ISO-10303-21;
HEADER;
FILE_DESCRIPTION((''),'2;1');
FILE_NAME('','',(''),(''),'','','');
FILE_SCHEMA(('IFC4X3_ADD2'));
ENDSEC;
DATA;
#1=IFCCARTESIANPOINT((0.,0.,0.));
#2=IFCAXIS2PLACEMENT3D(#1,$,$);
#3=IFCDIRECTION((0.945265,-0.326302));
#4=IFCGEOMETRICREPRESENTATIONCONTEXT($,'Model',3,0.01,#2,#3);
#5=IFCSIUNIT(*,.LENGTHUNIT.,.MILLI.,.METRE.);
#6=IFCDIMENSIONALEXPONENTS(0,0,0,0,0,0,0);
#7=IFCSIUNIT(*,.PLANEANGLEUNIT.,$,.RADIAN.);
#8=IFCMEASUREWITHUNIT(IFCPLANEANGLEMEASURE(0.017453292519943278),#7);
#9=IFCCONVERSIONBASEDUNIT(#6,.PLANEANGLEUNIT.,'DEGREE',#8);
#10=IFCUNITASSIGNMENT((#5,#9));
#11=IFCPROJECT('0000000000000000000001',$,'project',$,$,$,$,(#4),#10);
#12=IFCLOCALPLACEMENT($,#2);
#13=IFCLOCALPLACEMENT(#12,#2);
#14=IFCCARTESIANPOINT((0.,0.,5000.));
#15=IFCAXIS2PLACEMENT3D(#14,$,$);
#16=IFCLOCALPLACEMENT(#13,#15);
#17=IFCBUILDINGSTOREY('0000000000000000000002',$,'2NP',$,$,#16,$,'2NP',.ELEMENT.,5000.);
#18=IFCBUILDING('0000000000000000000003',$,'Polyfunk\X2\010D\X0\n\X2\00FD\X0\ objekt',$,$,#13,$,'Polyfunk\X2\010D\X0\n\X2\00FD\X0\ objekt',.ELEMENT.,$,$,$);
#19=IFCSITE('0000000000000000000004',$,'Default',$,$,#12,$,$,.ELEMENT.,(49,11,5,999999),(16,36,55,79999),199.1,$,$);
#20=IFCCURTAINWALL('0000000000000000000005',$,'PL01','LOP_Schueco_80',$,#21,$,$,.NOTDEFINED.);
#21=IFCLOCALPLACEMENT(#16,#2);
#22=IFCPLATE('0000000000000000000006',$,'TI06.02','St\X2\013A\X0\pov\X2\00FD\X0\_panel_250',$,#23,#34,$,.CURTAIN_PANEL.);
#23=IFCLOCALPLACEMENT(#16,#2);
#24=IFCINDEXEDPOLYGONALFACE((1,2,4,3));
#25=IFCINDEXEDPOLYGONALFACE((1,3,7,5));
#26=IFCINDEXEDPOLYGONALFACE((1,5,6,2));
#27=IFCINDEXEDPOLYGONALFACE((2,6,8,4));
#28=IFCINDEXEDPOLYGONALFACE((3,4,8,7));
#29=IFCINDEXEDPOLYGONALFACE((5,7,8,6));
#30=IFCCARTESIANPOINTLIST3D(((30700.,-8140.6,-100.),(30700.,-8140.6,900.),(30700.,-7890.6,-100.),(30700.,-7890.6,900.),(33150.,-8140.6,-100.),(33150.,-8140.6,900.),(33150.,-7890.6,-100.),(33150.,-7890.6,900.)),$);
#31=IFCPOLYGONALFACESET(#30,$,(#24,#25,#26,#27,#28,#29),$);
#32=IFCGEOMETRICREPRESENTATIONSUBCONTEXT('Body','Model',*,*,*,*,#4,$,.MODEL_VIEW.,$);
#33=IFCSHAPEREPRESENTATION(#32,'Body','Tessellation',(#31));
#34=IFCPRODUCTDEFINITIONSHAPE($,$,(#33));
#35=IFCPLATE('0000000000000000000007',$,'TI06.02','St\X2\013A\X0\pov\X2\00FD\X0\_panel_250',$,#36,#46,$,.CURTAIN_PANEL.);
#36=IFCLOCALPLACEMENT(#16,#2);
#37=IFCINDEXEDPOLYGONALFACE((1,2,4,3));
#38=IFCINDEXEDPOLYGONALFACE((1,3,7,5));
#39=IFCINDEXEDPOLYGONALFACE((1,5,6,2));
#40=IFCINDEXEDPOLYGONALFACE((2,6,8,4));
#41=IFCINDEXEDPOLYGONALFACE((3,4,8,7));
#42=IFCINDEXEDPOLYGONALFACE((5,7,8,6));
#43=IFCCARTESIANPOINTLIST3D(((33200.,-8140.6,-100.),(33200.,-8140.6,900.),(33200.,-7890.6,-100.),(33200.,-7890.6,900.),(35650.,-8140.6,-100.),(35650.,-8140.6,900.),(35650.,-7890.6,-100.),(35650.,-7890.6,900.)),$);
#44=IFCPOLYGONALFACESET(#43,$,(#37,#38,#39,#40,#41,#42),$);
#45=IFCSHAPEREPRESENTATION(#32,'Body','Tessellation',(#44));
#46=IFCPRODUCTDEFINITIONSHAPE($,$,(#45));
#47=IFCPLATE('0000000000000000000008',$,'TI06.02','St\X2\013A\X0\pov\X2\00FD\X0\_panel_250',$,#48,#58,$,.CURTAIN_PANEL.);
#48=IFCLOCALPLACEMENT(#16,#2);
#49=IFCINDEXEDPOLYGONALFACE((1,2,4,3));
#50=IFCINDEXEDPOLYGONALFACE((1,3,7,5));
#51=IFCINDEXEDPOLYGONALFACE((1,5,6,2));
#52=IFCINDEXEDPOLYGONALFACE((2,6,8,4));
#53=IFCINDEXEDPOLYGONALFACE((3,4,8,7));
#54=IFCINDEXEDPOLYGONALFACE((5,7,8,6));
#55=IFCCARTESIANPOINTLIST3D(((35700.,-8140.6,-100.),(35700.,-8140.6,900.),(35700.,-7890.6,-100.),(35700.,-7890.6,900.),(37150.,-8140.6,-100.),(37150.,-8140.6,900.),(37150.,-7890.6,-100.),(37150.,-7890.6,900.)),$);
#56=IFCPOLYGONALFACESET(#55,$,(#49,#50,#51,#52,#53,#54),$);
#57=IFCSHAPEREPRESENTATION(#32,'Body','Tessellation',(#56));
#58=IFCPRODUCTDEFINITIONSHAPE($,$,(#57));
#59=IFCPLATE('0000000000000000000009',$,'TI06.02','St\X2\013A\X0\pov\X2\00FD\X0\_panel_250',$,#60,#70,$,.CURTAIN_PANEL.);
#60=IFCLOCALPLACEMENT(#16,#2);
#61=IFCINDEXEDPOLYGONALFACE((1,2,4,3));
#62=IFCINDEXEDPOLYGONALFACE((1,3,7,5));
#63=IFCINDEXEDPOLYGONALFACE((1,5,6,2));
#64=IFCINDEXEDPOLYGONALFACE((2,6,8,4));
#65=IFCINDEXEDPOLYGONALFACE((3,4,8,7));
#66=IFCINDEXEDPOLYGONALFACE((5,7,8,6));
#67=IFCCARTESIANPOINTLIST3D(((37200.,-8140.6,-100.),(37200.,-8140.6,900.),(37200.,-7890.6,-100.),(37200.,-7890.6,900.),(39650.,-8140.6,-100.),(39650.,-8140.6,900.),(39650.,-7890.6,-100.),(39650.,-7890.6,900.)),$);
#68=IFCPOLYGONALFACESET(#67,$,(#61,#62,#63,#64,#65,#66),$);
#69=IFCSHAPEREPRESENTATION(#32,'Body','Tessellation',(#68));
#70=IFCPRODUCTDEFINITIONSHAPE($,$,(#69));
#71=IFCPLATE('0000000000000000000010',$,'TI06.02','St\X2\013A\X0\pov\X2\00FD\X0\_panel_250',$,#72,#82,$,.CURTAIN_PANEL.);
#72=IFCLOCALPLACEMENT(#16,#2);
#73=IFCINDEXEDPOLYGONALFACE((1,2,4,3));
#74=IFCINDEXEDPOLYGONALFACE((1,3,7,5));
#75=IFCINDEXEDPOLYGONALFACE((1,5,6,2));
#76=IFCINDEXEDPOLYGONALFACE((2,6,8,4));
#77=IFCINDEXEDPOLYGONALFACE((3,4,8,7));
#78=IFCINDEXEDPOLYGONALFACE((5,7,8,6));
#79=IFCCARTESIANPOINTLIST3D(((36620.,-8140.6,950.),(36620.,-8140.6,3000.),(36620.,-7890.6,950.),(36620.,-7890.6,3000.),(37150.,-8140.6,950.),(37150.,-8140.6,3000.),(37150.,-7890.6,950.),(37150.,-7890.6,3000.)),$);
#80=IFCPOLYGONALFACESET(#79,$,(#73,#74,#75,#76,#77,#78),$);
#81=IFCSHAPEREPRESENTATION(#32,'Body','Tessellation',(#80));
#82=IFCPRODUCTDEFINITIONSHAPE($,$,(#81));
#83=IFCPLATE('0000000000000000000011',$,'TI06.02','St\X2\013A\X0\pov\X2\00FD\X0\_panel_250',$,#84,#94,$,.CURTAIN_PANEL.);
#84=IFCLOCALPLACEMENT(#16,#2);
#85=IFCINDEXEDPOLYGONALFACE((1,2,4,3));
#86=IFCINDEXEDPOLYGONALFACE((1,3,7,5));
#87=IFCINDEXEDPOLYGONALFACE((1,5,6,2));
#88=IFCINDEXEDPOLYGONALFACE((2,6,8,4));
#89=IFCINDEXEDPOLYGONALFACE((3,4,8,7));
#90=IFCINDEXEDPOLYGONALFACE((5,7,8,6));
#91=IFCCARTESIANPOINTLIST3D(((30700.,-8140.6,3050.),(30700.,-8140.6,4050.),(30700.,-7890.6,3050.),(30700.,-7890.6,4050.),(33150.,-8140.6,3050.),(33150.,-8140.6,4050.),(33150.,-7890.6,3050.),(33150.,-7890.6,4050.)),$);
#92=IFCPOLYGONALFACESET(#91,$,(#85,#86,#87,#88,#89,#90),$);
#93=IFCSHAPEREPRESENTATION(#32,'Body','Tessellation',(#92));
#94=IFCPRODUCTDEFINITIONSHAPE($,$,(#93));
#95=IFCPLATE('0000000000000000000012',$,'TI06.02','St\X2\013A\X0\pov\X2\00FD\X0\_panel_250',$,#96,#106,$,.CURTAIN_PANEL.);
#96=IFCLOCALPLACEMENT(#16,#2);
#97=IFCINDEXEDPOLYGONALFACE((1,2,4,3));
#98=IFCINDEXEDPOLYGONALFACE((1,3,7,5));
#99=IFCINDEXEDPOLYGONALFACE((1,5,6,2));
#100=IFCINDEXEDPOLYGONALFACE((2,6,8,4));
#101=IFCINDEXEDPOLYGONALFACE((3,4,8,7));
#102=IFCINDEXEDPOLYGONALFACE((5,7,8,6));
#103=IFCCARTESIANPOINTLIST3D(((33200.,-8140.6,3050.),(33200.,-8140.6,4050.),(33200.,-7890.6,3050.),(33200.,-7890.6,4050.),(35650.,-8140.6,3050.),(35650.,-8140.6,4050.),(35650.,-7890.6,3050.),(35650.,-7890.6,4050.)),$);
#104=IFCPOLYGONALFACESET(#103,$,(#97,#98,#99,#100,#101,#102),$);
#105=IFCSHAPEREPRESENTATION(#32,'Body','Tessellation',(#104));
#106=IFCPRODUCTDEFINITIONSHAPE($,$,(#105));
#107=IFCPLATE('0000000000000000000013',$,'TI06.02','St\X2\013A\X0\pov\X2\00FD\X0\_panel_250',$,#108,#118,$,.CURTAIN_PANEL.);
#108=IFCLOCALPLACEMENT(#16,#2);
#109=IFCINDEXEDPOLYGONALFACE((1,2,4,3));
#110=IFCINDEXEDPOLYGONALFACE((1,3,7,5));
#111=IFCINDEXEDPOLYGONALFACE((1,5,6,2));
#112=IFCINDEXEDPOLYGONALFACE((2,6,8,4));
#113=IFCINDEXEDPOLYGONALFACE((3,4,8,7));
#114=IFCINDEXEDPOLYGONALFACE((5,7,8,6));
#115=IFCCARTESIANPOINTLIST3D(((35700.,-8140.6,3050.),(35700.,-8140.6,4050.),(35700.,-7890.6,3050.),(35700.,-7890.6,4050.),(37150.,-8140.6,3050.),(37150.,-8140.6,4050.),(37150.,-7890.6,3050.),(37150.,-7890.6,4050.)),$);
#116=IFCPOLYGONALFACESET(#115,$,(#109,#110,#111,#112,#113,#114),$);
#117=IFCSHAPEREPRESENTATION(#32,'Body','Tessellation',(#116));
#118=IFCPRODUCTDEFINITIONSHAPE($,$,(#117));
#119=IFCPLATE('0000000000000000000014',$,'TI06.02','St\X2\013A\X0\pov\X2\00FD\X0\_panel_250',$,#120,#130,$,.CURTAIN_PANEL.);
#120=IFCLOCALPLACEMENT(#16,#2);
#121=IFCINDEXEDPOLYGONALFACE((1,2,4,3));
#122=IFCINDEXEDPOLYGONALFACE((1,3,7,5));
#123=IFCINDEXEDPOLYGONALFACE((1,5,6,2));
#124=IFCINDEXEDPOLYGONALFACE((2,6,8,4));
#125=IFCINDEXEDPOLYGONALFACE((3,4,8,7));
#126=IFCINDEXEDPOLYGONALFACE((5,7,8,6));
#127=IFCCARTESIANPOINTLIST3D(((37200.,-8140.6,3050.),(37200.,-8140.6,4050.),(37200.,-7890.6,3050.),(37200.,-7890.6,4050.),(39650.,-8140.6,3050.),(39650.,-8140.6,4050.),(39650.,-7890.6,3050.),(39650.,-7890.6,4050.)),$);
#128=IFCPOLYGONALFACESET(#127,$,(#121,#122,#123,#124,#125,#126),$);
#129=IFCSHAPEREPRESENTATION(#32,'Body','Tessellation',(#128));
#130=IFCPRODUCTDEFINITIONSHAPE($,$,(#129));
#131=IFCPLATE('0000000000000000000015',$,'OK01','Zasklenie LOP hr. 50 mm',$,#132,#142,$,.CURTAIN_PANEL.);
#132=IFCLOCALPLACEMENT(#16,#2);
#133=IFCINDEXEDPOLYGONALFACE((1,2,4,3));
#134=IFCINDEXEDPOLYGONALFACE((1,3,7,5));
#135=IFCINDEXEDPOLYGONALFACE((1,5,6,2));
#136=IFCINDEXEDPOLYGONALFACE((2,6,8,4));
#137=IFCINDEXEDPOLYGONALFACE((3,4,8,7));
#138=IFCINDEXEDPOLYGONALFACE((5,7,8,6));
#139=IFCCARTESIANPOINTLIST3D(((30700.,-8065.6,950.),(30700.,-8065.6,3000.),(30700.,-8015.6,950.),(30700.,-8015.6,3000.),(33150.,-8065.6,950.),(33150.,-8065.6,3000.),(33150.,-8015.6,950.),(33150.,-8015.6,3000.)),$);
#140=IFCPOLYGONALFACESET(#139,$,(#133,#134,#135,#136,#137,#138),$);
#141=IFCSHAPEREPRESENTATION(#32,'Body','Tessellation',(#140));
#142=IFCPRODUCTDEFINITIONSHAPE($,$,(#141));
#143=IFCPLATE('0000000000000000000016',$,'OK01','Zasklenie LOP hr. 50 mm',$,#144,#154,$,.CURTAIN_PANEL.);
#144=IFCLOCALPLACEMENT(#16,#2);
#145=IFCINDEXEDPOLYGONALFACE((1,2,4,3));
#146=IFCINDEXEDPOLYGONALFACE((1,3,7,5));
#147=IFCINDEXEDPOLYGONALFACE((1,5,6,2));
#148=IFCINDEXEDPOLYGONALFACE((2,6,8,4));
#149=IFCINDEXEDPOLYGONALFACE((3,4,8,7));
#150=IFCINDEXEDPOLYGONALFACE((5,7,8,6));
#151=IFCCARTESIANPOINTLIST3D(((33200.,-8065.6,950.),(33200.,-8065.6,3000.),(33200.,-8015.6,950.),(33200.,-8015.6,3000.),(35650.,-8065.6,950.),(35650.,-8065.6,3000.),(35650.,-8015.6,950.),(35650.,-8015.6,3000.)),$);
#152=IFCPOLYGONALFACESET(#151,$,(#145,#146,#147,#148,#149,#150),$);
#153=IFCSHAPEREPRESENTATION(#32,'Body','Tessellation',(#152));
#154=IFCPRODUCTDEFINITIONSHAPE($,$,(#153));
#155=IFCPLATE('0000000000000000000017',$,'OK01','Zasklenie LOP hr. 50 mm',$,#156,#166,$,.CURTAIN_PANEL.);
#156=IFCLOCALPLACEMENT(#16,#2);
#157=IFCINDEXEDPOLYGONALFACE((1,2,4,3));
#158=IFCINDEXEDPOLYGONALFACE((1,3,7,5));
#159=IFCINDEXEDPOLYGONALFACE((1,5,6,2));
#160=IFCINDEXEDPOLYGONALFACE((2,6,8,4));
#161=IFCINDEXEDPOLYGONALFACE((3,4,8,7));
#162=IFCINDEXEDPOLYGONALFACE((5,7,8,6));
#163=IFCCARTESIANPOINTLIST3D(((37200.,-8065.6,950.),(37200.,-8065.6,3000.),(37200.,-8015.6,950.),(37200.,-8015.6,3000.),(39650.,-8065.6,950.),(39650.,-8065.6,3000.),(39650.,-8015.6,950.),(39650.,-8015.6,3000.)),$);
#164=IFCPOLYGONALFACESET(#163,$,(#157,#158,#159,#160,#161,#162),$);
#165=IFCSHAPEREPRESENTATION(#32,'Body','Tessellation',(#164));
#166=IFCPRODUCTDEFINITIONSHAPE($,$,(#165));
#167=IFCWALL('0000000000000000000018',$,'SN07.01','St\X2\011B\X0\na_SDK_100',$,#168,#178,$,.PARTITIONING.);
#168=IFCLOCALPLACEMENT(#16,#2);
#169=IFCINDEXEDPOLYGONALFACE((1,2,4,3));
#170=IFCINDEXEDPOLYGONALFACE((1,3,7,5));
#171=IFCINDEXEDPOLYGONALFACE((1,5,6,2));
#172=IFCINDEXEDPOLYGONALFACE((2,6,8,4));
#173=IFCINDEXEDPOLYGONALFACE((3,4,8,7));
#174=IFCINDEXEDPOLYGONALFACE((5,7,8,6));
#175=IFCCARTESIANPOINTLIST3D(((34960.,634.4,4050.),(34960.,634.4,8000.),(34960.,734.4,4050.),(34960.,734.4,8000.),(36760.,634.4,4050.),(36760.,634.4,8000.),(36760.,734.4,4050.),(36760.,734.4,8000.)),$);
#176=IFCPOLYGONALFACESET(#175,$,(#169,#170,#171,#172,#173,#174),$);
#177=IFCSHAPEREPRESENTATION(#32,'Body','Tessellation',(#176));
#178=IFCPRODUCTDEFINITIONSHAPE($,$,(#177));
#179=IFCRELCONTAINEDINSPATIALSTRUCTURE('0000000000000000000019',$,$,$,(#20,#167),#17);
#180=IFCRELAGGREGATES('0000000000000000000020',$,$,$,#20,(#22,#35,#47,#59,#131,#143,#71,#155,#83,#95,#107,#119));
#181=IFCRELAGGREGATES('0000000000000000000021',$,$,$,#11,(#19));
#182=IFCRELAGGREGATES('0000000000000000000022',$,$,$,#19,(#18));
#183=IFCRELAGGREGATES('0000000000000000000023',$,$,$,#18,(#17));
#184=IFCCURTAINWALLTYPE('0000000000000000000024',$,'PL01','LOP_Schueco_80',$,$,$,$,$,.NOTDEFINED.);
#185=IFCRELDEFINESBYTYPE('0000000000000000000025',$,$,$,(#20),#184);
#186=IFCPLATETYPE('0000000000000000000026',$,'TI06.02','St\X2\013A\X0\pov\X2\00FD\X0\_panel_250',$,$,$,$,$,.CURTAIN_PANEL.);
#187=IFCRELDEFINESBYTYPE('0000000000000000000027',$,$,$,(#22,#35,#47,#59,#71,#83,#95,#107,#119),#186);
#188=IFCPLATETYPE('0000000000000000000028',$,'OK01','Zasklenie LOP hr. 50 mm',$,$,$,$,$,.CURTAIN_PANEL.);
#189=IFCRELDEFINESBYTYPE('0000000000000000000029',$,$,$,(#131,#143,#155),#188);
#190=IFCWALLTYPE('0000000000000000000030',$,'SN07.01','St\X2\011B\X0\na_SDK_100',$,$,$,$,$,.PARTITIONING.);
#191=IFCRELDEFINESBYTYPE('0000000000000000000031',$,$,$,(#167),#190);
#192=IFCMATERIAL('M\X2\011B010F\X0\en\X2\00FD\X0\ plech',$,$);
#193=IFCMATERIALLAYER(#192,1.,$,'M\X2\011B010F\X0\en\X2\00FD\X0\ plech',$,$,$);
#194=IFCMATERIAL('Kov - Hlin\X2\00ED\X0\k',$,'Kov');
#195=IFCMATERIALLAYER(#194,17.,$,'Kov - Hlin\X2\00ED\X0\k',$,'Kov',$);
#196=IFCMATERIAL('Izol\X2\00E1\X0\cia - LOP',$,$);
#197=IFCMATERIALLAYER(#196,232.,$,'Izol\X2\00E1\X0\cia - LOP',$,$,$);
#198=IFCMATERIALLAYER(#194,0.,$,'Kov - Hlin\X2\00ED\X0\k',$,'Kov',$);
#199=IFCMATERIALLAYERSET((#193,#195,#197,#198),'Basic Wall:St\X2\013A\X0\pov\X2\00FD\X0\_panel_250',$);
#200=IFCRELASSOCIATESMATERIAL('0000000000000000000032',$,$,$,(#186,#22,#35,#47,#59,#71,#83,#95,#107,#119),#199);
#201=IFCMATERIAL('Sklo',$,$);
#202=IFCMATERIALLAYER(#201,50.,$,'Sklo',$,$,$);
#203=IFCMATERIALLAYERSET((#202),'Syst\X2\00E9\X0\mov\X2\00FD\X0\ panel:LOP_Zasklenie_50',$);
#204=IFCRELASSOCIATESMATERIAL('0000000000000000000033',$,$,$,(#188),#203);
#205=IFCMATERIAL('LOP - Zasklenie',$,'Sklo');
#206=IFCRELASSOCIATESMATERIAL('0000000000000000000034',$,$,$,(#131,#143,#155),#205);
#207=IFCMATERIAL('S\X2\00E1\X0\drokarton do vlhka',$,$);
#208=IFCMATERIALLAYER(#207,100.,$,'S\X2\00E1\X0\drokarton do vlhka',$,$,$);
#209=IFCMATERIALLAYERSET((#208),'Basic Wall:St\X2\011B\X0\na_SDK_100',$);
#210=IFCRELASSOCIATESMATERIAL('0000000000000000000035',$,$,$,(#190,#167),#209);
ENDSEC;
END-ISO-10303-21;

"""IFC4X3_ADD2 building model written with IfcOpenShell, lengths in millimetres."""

from ifc_helpers import new_model, entity, si_unit, converted_unit, direction, frame, frame_2d, origin, origin_2d_with_axis, place, context, subcontext, project, spatial, polyline, rectangle, extrude, clip, bounded_halfspace, source, transform, mapped, material, layer, layer_set, layer_usage, type_object, type_shapes, element, aggregate, save


model = new_model("IFC4X3_ADD2")

# Units and contexts
model_context = context("Model", 3, precision=0.01, world=origin(), true_north=direction((0.945265, -0.326302)))
body_context = subcontext(model_context, "Body", "Model", "MODEL_VIEW")
ifc_project = project(units=[si_unit("LENGTHUNIT", "METRE", prefix="MILLI"), converted_unit("PLANEANGLEUNIT", "DEGREE", entity("IfcPlaneAngleMeasure", 0.017453292519943278), si_unit("PLANEANGLEUNIT", "RADIAN"), dimensions=[0, 0, 0, 0, 0, 0, 0])], contexts=[model_context])

# Site, building, storey
site_placement = place(None, origin())
site = spatial("IfcSite", under=ifc_project, at=site_placement, Name="Default", CompositionType="ELEMENT", RefLatitude=(49, 11, 5, 999999), RefLongitude=(16, 36, 55, 79999), RefElevation=199.1)
building_placement = place(site_placement, origin())
building = spatial("IfcBuilding", under=site, at=building_placement, Name="Polyfunkčný objekt", LongName="Polyfunkčný objekt", CompositionType="ELEMENT")
storey_placement = place(building_placement, frame((0.0, 0.0, 5000.0)))
storey = spatial("IfcBuildingStorey", under=building, at=storey_placement, Name="2NP", LongName="2NP", CompositionType="ELEMENT", Elevation=5000.0)

# Curtain wall, plates
curtain_wall_type = type_object("IfcCurtainWallType", Name="PL01", Description="LOP_Schueco_80", PredefinedType="NOTDEFINED")
curtain_wall_placement = place(storey_placement, frame((0.0, 0.0, -5000.0)))
curtain_wall = element("IfcCurtainWall", 1, at=curtain_wall_placement, inside=storey, type_object=curtain_wall_type, Name="PL01", Description="LOP_Schueco_80", PredefinedType="NOTDEFINED")
ifc_material_1 = material(Name="Měďený plech")
ifc_layer_1 = layer(ifc_material_1, 1.0, Name="Měďený plech")
ifc_material_2 = material(Name="Kov - Hliník", Category="Kov")
ifc_layer_2 = layer(ifc_material_2, 17.0, Name="Kov - Hliník", Category="Kov")
ifc_material_3 = material(Name="Izolácia - LOP")
ifc_layer_3 = layer(ifc_material_3, 232.0, Name="Izolácia - LOP")
ifc_layer_4 = layer(ifc_material_2, 0.0, Name="Kov - Hliník", Category="Kov")
ifc_layer_set_1 = layer_set([ifc_layer_1, ifc_layer_2, ifc_layer_3, ifc_layer_4], Name="Basic Wall:Stĺpový_panel_250")
ifc_layer_usage_1 = layer_usage(ifc_layer_set_1, "AXIS2", "POSITIVE", -125.0)
plate_type_1 = type_object("IfcPlateType", Name="TI06.02", Description="Stĺpový_panel_250", PredefinedType="CURTAIN_PANEL", material=ifc_layer_set_1)
plate_1_placement = place(storey_placement, frame((30700.0, -8015.6, -100.0)))
plate_1 = element("IfcPlate", 2, at=plate_1_placement, type_object=plate_type_1, material=ifc_layer_usage_1, Name="TI06.02", Description="Stĺpový_panel_250", PredefinedType="CURTAIN_PANEL", context=body_context, shape_type="SweptSolid", body=[
    extrude(rectangle(XDim=250.0, YDim=2450.0, at=frame_2d((0.0, 0.0), x_axis=(1.0, 0.0))), frame((1225.0, 0.0, 0.0), z_axis=(0.0, 0.0, 1.0), x_axis=(0.0, 1.0, 0.0)), (0.0, 0.0, 1.0), 1000.0),
])
ifc_layer_usage_2 = layer_usage(ifc_layer_set_1, "AXIS2", "POSITIVE", -125.0)
plate_2_placement = place(storey_placement, frame((33200.0, -8015.6, -100.0)))
plate_2 = element("IfcPlate", 3, at=plate_2_placement, type_object=plate_type_1, material=ifc_layer_usage_2, Name="TI06.02", Description="Stĺpový_panel_250", PredefinedType="CURTAIN_PANEL", context=body_context, shape_type="SweptSolid", body=[
    extrude(rectangle(XDim=250.0, YDim=2450.0, at=frame_2d((0.0, 0.0), x_axis=(1.0, 0.0))), frame((1225.0, 0.0, 0.0), z_axis=(0.0, 0.0, 1.0), x_axis=(0.0, 1.0, 0.0)), (0.0, 0.0, 1.0), 1000.0),
])
ifc_layer_usage_3 = layer_usage(ifc_layer_set_1, "AXIS2", "POSITIVE", -125.0)
plate_3_placement = place(storey_placement, frame((35700.0, -8015.6, -100.0)))
plate_3 = element("IfcPlate", 4, at=plate_3_placement, type_object=plate_type_1, material=ifc_layer_usage_3, Name="TI06.02", Description="Stĺpový_panel_250", PredefinedType="CURTAIN_PANEL", context=body_context, shape_type="SweptSolid", body=[
    extrude(rectangle(XDim=250.0, YDim=1450.0, at=frame_2d((0.0, 0.0), x_axis=(1.0, 0.0))), frame((725.0, 0.0, 0.0), z_axis=(0.0, 0.0, 1.0), x_axis=(0.0, 1.0, 0.0)), (0.0, 0.0, 1.0), 1000.0),
])
ifc_layer_usage_4 = layer_usage(ifc_layer_set_1, "AXIS2", "POSITIVE", -125.0)
plate_4_placement = place(storey_placement, frame((37200.0, -8015.6, -100.0)))
plate_4 = element("IfcPlate", 5, at=plate_4_placement, type_object=plate_type_1, material=ifc_layer_usage_4, Name="TI06.02", Description="Stĺpový_panel_250", PredefinedType="CURTAIN_PANEL", context=body_context, shape_type="SweptSolid", body=[
    extrude(rectangle(XDim=250.0, YDim=2450.0, at=frame_2d((0.0, 0.0), x_axis=(1.0, 0.0))), frame((1225.0, 0.0, 0.0), z_axis=(0.0, 0.0, 1.0), x_axis=(0.0, 1.0, 0.0)), (0.0, 0.0, 1.0), 1000.0),
])
ifc_layer_usage_5 = layer_usage(ifc_layer_set_1, "AXIS2", "POSITIVE", -125.0)
plate_5_placement = place(storey_placement, frame((36620.0, -8015.6, 950.0)))
plate_5 = element("IfcPlate", 6, at=plate_5_placement, type_object=plate_type_1, material=ifc_layer_usage_5, Name="TI06.02", Description="Stĺpový_panel_250", PredefinedType="CURTAIN_PANEL", context=body_context, shape_type="SweptSolid", body=[
    extrude(rectangle(XDim=250.0, YDim=530.0, at=frame_2d((0.0, 0.0), x_axis=(1.0, 0.0))), frame((265.0, 0.0, 0.0), z_axis=(0.0, 0.0, 1.0), x_axis=(0.0, 1.0, 0.0)), (0.0, 0.0, 1.0), 2050.0),
])
ifc_layer_usage_6 = layer_usage(ifc_layer_set_1, "AXIS2", "POSITIVE", -125.0)
plate_6_placement = place(storey_placement, frame((30700.0, -8015.6, 3050.0)))
plate_6 = element("IfcPlate", 7, at=plate_6_placement, type_object=plate_type_1, material=ifc_layer_usage_6, Name="TI06.02", Description="Stĺpový_panel_250", PredefinedType="CURTAIN_PANEL", context=body_context, shape_type="SweptSolid", body=[
    extrude(rectangle(XDim=250.0, YDim=2450.0, at=frame_2d((0.0, 0.0), x_axis=(1.0, 0.0))), frame((1225.0, 0.0, 0.0), z_axis=(0.0, 0.0, 1.0), x_axis=(0.0, 1.0, 0.0)), (0.0, 0.0, 1.0), 1000.0),
])
ifc_layer_usage_7 = layer_usage(ifc_layer_set_1, "AXIS2", "POSITIVE", -125.0)
plate_7_placement = place(storey_placement, frame((33200.0, -8015.6, 3050.0)))
plate_7 = element("IfcPlate", 8, at=plate_7_placement, type_object=plate_type_1, material=ifc_layer_usage_7, Name="TI06.02", Description="Stĺpový_panel_250", PredefinedType="CURTAIN_PANEL", context=body_context, shape_type="SweptSolid", body=[
    extrude(rectangle(XDim=250.0, YDim=2450.0, at=frame_2d((0.0, 0.0), x_axis=(1.0, 0.0))), frame((1225.0, 0.0, 0.0), z_axis=(0.0, 0.0, 1.0), x_axis=(0.0, 1.0, 0.0)), (0.0, 0.0, 1.0), 1000.0),
])
ifc_layer_usage_8 = layer_usage(ifc_layer_set_1, "AXIS2", "POSITIVE", -125.0)
plate_8_placement = place(storey_placement, frame((35700.0, -8015.6, 3050.0)))
plate_8 = element("IfcPlate", 9, at=plate_8_placement, type_object=plate_type_1, material=ifc_layer_usage_8, Name="TI06.02", Description="Stĺpový_panel_250", PredefinedType="CURTAIN_PANEL", context=body_context, shape_type="SweptSolid", body=[
    extrude(rectangle(XDim=250.0, YDim=1450.0, at=frame_2d((0.0, 0.0), x_axis=(1.0, 0.0))), frame((725.0, 0.0, 0.0), z_axis=(0.0, 0.0, 1.0), x_axis=(0.0, 1.0, 0.0)), (0.0, 0.0, 1.0), 1000.0),
])
ifc_layer_usage_9 = layer_usage(ifc_layer_set_1, "AXIS2", "POSITIVE", -125.0)
plate_9_placement = place(storey_placement, frame((37200.0, -8015.6, 3050.0)))
plate_9 = element("IfcPlate", 10, at=plate_9_placement, type_object=plate_type_1, material=ifc_layer_usage_9, Name="TI06.02", Description="Stĺpový_panel_250", PredefinedType="CURTAIN_PANEL", context=body_context, shape_type="SweptSolid", body=[
    extrude(rectangle(XDim=250.0, YDim=2450.0, at=frame_2d((0.0, 0.0), x_axis=(1.0, 0.0))), frame((1225.0, 0.0, 0.0), z_axis=(0.0, 0.0, 1.0), x_axis=(0.0, 1.0, 0.0)), (0.0, 0.0, 1.0), 1000.0),
])
ifc_material_4 = material(Name="LOP - Zasklenie", Category="Sklo")
ifc_material_5 = material(Name="Sklo")
ifc_layer_5 = layer(ifc_material_5, 50.0, Name="Sklo")
ifc_layer_set_2 = layer_set([ifc_layer_5], Name="Systémový panel:LOP_Zasklenie_50")
plate_type_2 = type_object("IfcPlateType", Name="OK01", Description="Zasklenie LOP hr. 50 mm", PredefinedType="CURTAIN_PANEL", material=ifc_layer_set_2)
shared_shape_1 = source(origin(), body_context, "Body", "SweptSolid", [
    extrude(rectangle(XDim=50.0, YDim=2450.0, at=origin_2d_with_axis()), frame((0.0, -25.0, 0.0), z_axis=(0.0, 0.0, 1.0), x_axis=(0.0, 1.0, 0.0)), (0.0, 0.0, 1.0), 2050.0),
])
type_shapes(plate_type_2, [shared_shape_1])
plate_10_placement = place(curtain_wall_placement, frame((31925.0, -8015.6, 5950.0)))
plate_10 = element("IfcPlate", 11, at=plate_10_placement, type_object=plate_type_2, material=ifc_material_4, Name="OK01", Description="Zasklenie LOP hr. 50 mm", PredefinedType="CURTAIN_PANEL", context=body_context, shape_type="MappedRepresentation", body=[
    mapped(shared_shape_1, transform((0.0, 0.0, 0.0), scale=1.0)),
])
plate_11_placement = place(curtain_wall_placement, frame((34425.0, -8015.6, 5950.0)))
plate_11 = element("IfcPlate", 12, at=plate_11_placement, type_object=plate_type_2, material=ifc_material_4, Name="OK01", Description="Zasklenie LOP hr. 50 mm", PredefinedType="CURTAIN_PANEL", context=body_context, shape_type="MappedRepresentation", body=[
    mapped(shared_shape_1, transform((0.0, 0.0, 0.0), scale=1.0)),
])
plate_12_placement = place(curtain_wall_placement, frame((38425.0, -8015.6, 5950.0)))
plate_12 = element("IfcPlate", 13, at=plate_12_placement, type_object=plate_type_2, material=ifc_material_4, Name="OK01", Description="Zasklenie LOP hr. 50 mm", PredefinedType="CURTAIN_PANEL", context=body_context, shape_type="MappedRepresentation", body=[
    mapped(shared_shape_1, transform((0.0, 0.0, 0.0), scale=1.0)),
])

# Wall
ifc_material_6 = material(Name="Sádrokarton do vlhka")
ifc_layer_6 = layer(ifc_material_6, 100.0, Name="Sádrokarton do vlhka")
ifc_layer_set_3 = layer_set([ifc_layer_6], Name="Basic Wall:Stěna_SDK_100")
wall_type_1 = type_object("IfcWallType", Name="SN07.01", Description="Stěna_SDK_100", PredefinedType="PARTITIONING", material=ifc_layer_set_3)
wall_1_placement = place(storey_placement, frame((34960.0, 684.4, 4050.0)))
element("IfcWall", 14, at=wall_1_placement, inside=storey, type_object=wall_type_1, material=ifc_layer_set_3, Name="SN07.01", Description="Stěna_SDK_100", PredefinedType="PARTITIONING", context=body_context, shape_type="Clipping", body=[
    clip(clip(extrude(rectangle(XDim=1800.0, YDim=100.0, at=frame_2d((900.0, 0.0), x_axis=(-1.0, 0.0))), origin(), (0.0, 0.0, 1.0), 3950.0), bounded_halfspace(frame((1800.0, -50.0, 0.0), z_axis=(0.0, 0.0, 1.0), x_axis=(-1.0, 0.0, 0.0)), True, frame((1800.0, -50.0, 0.0)), polyline([(0.0, 0.0), (0.0, 100.0), (-1800.0, 100.0), (-1800.0, 0.0), (0.0, 0.0)]))), bounded_halfspace(frame((0.0, -50.0, 3950.0), z_axis=(0.0, 0.0, -1.0), x_axis=(1.0, 0.0, 0.0)), True, frame((0.0, -50.0, 3950.0)), polyline([(0.0, 0.0), (1800.0, 0.0), (1800.0, 100.0), (0.0, 100.0), (0.0, 0.0)]))),
])

aggregate(curtain_wall, [plate_1, plate_2, plate_3, plate_4, plate_10, plate_11, plate_5, plate_12, plate_6, plate_7, plate_8, plate_9])

save(model, "model.ifc")
